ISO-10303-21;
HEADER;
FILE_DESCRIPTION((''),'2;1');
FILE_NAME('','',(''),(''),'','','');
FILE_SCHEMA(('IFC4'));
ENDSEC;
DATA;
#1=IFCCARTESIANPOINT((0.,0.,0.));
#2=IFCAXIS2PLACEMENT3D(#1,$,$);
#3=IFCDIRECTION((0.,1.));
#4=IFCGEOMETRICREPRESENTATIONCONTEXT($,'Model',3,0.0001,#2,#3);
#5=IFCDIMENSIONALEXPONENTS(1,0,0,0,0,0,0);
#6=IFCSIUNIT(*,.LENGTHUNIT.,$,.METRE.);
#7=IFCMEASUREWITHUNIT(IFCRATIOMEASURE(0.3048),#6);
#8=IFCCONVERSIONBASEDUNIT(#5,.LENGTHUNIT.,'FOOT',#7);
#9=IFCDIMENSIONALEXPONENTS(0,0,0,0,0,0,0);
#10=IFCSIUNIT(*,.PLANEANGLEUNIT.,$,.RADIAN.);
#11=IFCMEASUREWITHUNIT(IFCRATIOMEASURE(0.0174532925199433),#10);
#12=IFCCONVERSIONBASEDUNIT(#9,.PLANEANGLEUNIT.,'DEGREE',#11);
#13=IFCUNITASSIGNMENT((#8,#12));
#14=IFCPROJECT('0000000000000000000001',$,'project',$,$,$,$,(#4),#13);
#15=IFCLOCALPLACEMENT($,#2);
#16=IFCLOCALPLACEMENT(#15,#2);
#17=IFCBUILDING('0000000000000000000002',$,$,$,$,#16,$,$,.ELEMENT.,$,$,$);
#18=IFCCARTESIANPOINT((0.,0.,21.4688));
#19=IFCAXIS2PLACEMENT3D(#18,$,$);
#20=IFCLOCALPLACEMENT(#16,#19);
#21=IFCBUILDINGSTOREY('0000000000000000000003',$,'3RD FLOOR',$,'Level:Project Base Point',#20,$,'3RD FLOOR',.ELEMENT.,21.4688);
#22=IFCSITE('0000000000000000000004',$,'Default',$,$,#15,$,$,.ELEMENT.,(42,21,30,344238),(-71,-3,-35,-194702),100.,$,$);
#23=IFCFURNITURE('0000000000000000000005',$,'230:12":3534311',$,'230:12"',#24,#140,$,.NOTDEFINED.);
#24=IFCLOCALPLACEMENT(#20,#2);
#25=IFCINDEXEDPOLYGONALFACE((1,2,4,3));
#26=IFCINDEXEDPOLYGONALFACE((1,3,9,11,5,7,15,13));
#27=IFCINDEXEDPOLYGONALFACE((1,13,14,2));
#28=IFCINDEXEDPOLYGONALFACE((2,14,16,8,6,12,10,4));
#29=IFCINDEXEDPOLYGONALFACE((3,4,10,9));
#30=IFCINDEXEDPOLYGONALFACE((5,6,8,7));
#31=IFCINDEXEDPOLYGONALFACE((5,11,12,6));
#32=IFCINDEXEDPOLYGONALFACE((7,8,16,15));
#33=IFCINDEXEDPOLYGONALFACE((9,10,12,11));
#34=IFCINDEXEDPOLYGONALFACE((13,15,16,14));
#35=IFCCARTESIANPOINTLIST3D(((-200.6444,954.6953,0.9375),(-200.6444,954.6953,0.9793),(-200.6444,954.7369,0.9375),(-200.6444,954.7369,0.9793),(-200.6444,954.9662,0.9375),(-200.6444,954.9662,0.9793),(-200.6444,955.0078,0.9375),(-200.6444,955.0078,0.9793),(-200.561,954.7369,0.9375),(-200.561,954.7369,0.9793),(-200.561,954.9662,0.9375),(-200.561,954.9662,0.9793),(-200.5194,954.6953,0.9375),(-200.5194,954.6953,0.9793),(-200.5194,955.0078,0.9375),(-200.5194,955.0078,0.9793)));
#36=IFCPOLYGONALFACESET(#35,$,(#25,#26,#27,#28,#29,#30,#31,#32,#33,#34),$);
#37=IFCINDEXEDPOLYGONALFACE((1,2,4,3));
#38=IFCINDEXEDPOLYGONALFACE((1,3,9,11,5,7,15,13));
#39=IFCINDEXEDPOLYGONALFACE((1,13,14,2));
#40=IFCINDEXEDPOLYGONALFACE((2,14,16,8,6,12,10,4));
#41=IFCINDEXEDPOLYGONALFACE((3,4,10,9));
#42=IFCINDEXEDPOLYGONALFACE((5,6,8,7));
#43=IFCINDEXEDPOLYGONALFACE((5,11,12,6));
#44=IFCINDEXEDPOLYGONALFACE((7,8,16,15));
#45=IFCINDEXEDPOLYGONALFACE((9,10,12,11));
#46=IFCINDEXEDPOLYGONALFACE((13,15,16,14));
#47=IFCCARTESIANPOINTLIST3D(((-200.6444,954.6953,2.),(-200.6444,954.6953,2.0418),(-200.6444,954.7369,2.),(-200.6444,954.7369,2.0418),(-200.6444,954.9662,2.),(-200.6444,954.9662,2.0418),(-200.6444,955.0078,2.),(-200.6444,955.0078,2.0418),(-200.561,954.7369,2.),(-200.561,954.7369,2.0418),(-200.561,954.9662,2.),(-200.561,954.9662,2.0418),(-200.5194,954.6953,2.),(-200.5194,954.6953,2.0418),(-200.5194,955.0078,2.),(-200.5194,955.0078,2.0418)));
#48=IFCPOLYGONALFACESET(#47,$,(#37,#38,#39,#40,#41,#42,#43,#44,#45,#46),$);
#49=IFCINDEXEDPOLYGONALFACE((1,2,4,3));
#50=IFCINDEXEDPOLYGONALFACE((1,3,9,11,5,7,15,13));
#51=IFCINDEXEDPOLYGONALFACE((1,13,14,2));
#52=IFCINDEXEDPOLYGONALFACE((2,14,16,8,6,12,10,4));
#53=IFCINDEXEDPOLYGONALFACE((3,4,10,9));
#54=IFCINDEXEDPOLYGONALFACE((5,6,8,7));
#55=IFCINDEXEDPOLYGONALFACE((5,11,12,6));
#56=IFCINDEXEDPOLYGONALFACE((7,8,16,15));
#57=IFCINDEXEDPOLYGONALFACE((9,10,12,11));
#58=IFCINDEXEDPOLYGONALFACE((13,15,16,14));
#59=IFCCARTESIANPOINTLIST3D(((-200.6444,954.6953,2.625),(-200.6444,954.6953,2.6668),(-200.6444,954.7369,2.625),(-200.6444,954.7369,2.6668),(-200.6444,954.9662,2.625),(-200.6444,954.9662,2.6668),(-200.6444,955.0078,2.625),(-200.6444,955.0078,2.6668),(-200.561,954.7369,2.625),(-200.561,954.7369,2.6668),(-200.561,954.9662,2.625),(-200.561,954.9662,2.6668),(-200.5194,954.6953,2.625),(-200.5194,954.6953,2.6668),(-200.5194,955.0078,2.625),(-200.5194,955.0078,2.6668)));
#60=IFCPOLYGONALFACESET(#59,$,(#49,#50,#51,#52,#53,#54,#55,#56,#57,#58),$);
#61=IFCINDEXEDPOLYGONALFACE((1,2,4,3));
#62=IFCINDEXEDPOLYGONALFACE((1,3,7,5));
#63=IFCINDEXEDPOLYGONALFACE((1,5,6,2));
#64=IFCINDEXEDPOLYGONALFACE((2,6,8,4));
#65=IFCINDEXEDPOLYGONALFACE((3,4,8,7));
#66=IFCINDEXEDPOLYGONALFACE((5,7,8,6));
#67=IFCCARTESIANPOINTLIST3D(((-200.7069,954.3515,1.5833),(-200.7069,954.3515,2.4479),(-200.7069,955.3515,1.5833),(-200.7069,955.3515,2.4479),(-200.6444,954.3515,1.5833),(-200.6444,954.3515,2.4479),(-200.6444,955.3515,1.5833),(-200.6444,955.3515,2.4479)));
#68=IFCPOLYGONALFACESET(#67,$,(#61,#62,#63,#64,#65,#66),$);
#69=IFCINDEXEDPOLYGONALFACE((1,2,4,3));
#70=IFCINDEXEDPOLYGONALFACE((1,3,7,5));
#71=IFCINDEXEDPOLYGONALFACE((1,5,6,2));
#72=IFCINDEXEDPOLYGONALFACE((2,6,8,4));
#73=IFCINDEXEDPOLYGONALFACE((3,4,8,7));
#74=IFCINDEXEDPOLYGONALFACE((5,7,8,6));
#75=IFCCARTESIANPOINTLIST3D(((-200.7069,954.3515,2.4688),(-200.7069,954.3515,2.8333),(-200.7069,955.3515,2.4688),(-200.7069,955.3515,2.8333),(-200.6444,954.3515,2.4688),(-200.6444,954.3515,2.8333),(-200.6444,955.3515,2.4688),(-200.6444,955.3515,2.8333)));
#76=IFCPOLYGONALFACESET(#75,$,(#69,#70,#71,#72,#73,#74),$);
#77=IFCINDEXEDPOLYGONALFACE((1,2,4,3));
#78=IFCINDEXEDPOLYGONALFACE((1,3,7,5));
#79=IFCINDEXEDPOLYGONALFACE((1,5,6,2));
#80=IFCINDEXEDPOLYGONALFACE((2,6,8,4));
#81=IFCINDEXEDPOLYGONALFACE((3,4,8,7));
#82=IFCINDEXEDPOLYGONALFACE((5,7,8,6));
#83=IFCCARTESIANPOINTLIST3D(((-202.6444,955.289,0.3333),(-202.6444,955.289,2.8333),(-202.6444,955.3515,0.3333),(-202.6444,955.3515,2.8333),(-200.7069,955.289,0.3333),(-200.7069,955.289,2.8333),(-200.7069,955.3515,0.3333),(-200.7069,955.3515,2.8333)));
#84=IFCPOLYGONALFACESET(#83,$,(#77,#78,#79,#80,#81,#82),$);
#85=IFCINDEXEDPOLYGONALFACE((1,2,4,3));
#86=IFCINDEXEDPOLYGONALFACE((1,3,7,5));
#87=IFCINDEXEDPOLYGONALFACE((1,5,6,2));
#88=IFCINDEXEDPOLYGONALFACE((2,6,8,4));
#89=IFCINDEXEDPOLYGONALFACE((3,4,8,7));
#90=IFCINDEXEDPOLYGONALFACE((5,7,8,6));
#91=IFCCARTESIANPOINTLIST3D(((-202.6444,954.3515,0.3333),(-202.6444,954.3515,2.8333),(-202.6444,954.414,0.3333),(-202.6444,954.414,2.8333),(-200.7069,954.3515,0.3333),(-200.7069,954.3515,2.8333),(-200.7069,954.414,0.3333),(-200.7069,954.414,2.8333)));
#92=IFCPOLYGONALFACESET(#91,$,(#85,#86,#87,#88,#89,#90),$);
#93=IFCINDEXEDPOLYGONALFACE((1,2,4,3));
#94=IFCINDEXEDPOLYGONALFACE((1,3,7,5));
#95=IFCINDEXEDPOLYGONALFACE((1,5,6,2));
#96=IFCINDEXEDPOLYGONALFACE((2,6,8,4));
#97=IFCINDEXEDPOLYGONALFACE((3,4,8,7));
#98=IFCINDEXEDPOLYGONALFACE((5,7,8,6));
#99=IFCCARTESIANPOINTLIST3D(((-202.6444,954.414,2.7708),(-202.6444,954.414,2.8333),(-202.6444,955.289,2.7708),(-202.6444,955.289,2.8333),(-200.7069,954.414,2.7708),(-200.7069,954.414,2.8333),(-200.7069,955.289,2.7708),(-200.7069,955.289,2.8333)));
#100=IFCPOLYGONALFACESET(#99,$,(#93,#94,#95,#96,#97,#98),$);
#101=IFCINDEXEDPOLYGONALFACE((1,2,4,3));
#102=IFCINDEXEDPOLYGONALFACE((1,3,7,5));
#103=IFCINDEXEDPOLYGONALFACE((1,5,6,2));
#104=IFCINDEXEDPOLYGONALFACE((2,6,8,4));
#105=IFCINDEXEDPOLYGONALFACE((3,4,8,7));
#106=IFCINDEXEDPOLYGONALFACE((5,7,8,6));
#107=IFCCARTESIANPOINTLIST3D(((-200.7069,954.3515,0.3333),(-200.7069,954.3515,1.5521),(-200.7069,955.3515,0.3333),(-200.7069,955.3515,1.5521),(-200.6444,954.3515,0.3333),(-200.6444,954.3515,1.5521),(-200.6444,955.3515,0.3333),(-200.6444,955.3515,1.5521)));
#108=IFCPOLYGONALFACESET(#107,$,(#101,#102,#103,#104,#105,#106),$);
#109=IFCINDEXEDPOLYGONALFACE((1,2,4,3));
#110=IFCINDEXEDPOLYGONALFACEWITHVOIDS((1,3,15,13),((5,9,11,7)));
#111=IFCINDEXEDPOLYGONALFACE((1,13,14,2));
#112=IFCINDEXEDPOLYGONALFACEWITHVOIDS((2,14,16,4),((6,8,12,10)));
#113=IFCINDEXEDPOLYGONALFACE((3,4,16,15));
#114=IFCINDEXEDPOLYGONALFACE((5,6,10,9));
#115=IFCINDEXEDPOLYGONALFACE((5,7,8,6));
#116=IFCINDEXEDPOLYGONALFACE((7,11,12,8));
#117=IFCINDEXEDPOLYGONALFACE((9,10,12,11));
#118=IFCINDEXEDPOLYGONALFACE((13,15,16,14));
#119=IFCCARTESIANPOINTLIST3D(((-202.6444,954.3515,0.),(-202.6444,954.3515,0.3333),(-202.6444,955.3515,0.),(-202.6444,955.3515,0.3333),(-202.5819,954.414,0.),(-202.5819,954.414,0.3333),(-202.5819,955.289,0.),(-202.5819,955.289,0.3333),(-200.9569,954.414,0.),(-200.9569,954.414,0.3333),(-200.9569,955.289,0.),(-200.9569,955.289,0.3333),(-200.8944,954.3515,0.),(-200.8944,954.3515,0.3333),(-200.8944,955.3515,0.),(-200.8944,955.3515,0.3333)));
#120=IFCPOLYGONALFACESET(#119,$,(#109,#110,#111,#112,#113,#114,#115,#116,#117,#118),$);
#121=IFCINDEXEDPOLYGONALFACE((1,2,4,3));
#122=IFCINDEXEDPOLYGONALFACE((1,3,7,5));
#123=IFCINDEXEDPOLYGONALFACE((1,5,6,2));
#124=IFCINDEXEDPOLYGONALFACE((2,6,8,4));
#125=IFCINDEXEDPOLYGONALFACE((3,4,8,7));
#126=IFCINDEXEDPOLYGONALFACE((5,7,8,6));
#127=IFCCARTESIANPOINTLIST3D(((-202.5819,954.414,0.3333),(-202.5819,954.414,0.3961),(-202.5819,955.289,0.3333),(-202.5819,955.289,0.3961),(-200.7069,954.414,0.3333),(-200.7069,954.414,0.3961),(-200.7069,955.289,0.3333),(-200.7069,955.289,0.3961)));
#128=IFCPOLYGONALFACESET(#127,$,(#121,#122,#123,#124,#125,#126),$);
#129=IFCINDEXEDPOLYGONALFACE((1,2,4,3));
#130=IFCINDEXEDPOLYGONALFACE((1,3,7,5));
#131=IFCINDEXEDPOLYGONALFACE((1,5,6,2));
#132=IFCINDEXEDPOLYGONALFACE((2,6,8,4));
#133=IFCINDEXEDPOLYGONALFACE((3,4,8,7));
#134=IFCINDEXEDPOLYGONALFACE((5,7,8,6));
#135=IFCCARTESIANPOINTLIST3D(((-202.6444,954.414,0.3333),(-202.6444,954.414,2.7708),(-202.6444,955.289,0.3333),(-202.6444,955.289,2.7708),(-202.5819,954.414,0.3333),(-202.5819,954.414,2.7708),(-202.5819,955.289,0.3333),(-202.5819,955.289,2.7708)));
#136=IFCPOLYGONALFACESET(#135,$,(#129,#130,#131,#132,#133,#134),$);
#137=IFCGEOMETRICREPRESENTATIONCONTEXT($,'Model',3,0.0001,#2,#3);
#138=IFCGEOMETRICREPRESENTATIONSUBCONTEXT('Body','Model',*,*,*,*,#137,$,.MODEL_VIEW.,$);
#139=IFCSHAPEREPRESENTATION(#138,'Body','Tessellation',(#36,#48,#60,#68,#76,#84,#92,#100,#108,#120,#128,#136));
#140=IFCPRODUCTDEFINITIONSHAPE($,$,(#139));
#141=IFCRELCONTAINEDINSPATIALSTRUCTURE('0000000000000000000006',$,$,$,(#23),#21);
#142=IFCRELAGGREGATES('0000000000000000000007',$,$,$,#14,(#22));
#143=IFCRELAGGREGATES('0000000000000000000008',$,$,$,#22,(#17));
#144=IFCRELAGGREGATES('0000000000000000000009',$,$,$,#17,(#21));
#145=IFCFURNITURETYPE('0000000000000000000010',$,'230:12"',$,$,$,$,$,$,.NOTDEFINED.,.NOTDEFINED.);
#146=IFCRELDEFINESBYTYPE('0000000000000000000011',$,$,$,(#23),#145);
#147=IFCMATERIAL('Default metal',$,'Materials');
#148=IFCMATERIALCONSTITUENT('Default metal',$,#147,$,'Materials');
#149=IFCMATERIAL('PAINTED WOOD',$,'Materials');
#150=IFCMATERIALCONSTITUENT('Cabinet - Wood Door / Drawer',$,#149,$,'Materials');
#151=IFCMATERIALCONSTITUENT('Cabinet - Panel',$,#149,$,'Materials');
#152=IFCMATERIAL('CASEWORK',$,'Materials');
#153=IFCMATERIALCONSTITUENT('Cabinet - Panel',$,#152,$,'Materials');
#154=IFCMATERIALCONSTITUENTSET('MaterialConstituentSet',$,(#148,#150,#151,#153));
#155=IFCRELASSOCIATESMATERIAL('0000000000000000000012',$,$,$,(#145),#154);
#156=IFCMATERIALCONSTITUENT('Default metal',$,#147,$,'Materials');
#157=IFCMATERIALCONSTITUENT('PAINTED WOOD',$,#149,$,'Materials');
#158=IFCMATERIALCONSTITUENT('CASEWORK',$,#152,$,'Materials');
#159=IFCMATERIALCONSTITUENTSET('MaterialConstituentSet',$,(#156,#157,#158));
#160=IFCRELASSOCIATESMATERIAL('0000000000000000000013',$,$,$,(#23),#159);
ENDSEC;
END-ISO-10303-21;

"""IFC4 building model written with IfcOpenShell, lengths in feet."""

from ifc_helpers import new_model, entity, si_unit, converted_unit, direction, frame, frame_2d, origin, origin_2d_with_axis, place, context, subcontext, project, spatial, polyline, rectangle, outline, extrude, source, transform, mapped, material, constituent, constituent_set, type_object, type_shapes, element, save


model = new_model("IFC4")

# Units and contexts
model_context_1 = context("Model", 3, precision=0.0001, world=origin(), true_north=direction((0.0, 1.0)))
model_context_2 = context("Model", 3, precision=0.0001, world=origin(), true_north=direction((0.0, 1.0)))
body_context = subcontext(model_context_2, "Body", "Model", "MODEL_VIEW")
ifc_project = project(units=[converted_unit("LENGTHUNIT", "FOOT", entity("IfcRatioMeasure", 0.3048), si_unit("LENGTHUNIT", "METRE"), dimensions=[1, 0, 0, 0, 0, 0, 0]), converted_unit("PLANEANGLEUNIT", "DEGREE", entity("IfcRatioMeasure", 0.0174532925199433), si_unit("PLANEANGLEUNIT", "RADIAN"), dimensions=[0, 0, 0, 0, 0, 0, 0])], contexts=[model_context_1])

# Site, building, storey
site_placement = place(None, origin())
site = spatial("IfcSite", under=ifc_project, at=site_placement, Name="Default", CompositionType="ELEMENT", RefLatitude=(42, 21, 30, 344238), RefLongitude=(-71, -3, -35, -194702), RefElevation=100.0)
building_placement = place(site_placement, origin())
building = spatial("IfcBuilding", under=site, at=building_placement, CompositionType="ELEMENT")
storey_placement = place(building_placement, frame((0.0, 0.0, 21.4688)))
storey = spatial("IfcBuildingStorey", under=building, at=storey_placement, Name="3RD FLOOR", ObjectType="Level:Project Base Point", LongName="3RD FLOOR", CompositionType="ELEMENT", Elevation=21.4688)

# Furniture
ifc_material_1 = material(Name="CASEWORK", Category="Materials")
ifc_material_2 = material(Name="Default metal", Category="Materials")
ifc_material_3 = material(Name="PAINTED WOOD", Category="Materials")
ifc_constituent_1 = constituent(ifc_material_2, Name="Default metal", Category="Materials")
ifc_constituent_2 = constituent(ifc_material_3, Name="PAINTED WOOD", Category="Materials")
ifc_constituent_3 = constituent(ifc_material_1, Name="CASEWORK", Category="Materials")
ifc_constituent_set_1 = constituent_set(constituents=[ifc_constituent_1, ifc_constituent_2, ifc_constituent_3], Name="MaterialConstituentSet")
ifc_constituent_4 = constituent(ifc_material_2, Name="Default metal", Category="Materials")
ifc_constituent_5 = constituent(ifc_material_3, Name="Cabinet - Wood Door / Drawer", Category="Materials")
ifc_constituent_6 = constituent(ifc_material_3, Name="Cabinet - Panel", Category="Materials")
ifc_constituent_7 = constituent(ifc_material_1, Name="Cabinet - Panel", Category="Materials")
ifc_constituent_set_2 = constituent_set(constituents=[ifc_constituent_4, ifc_constituent_5, ifc_constituent_6, ifc_constituent_7], Name="MaterialConstituentSet")
furniture_type_1 = type_object("IfcFurnitureType", Name="230:12\"", AssemblyPlace="NOTDEFINED", PredefinedType="NOTDEFINED", material=ifc_constituent_set_2)
shared_shape_1 = source(origin(), body_context, "Body", "SweptSolid", [
    extrude(outline(polyline([(-0.1562, -0.0521), (-0.1146, -0.0521), (-0.1146, 0.0313), (0.1146, 0.0313), (0.1146, -0.0521), (0.1562, -0.0521), (0.1562, 0.0729), (-0.1562, 0.0729), (-0.1562, -0.0521)])), frame((0.0615, 2.0521, 0.9375)), (0.0, 0.0, 1.0), 0.0418),
    extrude(outline(polyline([(-0.1562, -0.0521), (-0.1146, -0.0521), (-0.1146, 0.0313), (0.1146, 0.0313), (0.1146, -0.0521), (0.1562, -0.0521), (0.1562, 0.0729), (-0.1562, 0.0729), (-0.1562, -0.0521)])), frame((0.0615, 2.0521, 2.0)), (0.0, 0.0, 1.0), 0.0418),
    extrude(outline(polyline([(-0.1562, -0.0521), (-0.1146, -0.0521), (-0.1146, 0.0313), (0.1146, 0.0313), (0.1146, -0.0521), (0.1562, -0.0521), (0.1562, 0.0729), (-0.1562, 0.0729), (-0.1562, -0.0521)])), frame((0.0615, 2.0521, 2.625)), (0.0, 0.0, 1.0), 0.0418),
    extrude(rectangle(XDim=1.0, YDim=0.0625, at=origin_2d_with_axis()), frame((0.0615, 1.9688, 1.5833), z_axis=(0.0, 0.0, 1.0), x_axis=(-1.0, 0.0, 0.0)), (0.0, 0.0, 1.0), 0.8646),
    extrude(rectangle(XDim=1.0, YDim=0.0625, at=origin_2d_with_axis()), frame((0.0615, 1.9688, 2.4688), z_axis=(0.0, 0.0, 1.0), x_axis=(-1.0, 0.0, 0.0)), (0.0, 0.0, 1.0), 0.3646),
    extrude(rectangle(XDim=1.9375, YDim=0.0625, at=frame_2d((0.0, 0.0), x_axis=(1.0, 0.0))), frame((-0.4073, 0.9687, 0.3333), z_axis=(0.0, 0.0, 1.0), x_axis=(0.0, -1.0, 0.0)), (0.0, 0.0, 1.0), 2.5),
    extrude(rectangle(XDim=1.9375, YDim=0.0625, at=frame_2d((0.0, 0.0), x_axis=(1.0, 0.0))), frame((0.5302, 0.9687, 0.3333), z_axis=(0.0, 0.0, 1.0), x_axis=(0.0, -1.0, 0.0)), (0.0, 0.0, 1.0), 2.5),
    extrude(rectangle(XDim=1.9375, YDim=0.875, at=origin_2d_with_axis()), frame((0.0615, 0.9687, 2.7708), z_axis=(0.0, 0.0, 1.0), x_axis=(0.0, 1.0, 0.0)), (0.0, 0.0, 1.0), 0.0625),
    extrude(rectangle(XDim=1.0, YDim=0.0625, at=origin_2d_with_axis()), frame((0.0615, 1.9688, 0.3333), z_axis=(0.0, 0.0, 1.0), x_axis=(-1.0, 0.0, 0.0)), (0.0, 0.0, 1.0), 1.2187),
    extrude(outline(polyline([(-0.875, -0.5), (0.875, -0.5), (0.875, 0.5), (-0.875, 0.5), (-0.875, -0.5)]), holes=[polyline([(-0.8125, -0.4375), (-0.8125, 0.4375), (0.8125, 0.4375), (0.8125, -0.4375), (-0.8125, -0.4375)])]), frame((0.0615, 0.875, 0.0), z_axis=(0.0, 0.0, 1.0), x_axis=(0.0, -1.0, 0.0)), (0.0, 0.0, 1.0), 0.3333),
    extrude(rectangle(XDim=1.875, YDim=0.875, at=origin_2d_with_axis()), frame((0.0615, 1.0, 0.3333), z_axis=(0.0, 0.0, 1.0), x_axis=(0.0, 1.0, 0.0)), (0.0, 0.0, 1.0), 0.0627),
    extrude(rectangle(XDim=0.875, YDim=0.0625, at=origin_2d_with_axis()), frame((0.0615, 0.0312, 0.3333), z_axis=(0.0, 0.0, 1.0), x_axis=(-1.0, 0.0, 0.0)), (0.0, 0.0, 1.0), 2.4375),
])
type_shapes(furniture_type_1, [shared_shape_1])
furniture_1_placement = place(storey_placement, frame((-202.6444, 954.913, 0.0), z_axis=(0.0, 0.0, 1.0), x_axis=(0.0, -1.0, 0.0)))
element("IfcFurniture", 1, at=furniture_1_placement, inside=storey, type_object=furniture_type_1, material=ifc_constituent_set_1, Name="230:12\":3534311", ObjectType="230:12\"", PredefinedType="NOTDEFINED", context=body_context, shape_type="MappedRepresentation", body=[
    mapped(shared_shape_1, transform((0.0, 0.0, 0.0), scale=1.0)),
])

save(model, "model.ifc")
